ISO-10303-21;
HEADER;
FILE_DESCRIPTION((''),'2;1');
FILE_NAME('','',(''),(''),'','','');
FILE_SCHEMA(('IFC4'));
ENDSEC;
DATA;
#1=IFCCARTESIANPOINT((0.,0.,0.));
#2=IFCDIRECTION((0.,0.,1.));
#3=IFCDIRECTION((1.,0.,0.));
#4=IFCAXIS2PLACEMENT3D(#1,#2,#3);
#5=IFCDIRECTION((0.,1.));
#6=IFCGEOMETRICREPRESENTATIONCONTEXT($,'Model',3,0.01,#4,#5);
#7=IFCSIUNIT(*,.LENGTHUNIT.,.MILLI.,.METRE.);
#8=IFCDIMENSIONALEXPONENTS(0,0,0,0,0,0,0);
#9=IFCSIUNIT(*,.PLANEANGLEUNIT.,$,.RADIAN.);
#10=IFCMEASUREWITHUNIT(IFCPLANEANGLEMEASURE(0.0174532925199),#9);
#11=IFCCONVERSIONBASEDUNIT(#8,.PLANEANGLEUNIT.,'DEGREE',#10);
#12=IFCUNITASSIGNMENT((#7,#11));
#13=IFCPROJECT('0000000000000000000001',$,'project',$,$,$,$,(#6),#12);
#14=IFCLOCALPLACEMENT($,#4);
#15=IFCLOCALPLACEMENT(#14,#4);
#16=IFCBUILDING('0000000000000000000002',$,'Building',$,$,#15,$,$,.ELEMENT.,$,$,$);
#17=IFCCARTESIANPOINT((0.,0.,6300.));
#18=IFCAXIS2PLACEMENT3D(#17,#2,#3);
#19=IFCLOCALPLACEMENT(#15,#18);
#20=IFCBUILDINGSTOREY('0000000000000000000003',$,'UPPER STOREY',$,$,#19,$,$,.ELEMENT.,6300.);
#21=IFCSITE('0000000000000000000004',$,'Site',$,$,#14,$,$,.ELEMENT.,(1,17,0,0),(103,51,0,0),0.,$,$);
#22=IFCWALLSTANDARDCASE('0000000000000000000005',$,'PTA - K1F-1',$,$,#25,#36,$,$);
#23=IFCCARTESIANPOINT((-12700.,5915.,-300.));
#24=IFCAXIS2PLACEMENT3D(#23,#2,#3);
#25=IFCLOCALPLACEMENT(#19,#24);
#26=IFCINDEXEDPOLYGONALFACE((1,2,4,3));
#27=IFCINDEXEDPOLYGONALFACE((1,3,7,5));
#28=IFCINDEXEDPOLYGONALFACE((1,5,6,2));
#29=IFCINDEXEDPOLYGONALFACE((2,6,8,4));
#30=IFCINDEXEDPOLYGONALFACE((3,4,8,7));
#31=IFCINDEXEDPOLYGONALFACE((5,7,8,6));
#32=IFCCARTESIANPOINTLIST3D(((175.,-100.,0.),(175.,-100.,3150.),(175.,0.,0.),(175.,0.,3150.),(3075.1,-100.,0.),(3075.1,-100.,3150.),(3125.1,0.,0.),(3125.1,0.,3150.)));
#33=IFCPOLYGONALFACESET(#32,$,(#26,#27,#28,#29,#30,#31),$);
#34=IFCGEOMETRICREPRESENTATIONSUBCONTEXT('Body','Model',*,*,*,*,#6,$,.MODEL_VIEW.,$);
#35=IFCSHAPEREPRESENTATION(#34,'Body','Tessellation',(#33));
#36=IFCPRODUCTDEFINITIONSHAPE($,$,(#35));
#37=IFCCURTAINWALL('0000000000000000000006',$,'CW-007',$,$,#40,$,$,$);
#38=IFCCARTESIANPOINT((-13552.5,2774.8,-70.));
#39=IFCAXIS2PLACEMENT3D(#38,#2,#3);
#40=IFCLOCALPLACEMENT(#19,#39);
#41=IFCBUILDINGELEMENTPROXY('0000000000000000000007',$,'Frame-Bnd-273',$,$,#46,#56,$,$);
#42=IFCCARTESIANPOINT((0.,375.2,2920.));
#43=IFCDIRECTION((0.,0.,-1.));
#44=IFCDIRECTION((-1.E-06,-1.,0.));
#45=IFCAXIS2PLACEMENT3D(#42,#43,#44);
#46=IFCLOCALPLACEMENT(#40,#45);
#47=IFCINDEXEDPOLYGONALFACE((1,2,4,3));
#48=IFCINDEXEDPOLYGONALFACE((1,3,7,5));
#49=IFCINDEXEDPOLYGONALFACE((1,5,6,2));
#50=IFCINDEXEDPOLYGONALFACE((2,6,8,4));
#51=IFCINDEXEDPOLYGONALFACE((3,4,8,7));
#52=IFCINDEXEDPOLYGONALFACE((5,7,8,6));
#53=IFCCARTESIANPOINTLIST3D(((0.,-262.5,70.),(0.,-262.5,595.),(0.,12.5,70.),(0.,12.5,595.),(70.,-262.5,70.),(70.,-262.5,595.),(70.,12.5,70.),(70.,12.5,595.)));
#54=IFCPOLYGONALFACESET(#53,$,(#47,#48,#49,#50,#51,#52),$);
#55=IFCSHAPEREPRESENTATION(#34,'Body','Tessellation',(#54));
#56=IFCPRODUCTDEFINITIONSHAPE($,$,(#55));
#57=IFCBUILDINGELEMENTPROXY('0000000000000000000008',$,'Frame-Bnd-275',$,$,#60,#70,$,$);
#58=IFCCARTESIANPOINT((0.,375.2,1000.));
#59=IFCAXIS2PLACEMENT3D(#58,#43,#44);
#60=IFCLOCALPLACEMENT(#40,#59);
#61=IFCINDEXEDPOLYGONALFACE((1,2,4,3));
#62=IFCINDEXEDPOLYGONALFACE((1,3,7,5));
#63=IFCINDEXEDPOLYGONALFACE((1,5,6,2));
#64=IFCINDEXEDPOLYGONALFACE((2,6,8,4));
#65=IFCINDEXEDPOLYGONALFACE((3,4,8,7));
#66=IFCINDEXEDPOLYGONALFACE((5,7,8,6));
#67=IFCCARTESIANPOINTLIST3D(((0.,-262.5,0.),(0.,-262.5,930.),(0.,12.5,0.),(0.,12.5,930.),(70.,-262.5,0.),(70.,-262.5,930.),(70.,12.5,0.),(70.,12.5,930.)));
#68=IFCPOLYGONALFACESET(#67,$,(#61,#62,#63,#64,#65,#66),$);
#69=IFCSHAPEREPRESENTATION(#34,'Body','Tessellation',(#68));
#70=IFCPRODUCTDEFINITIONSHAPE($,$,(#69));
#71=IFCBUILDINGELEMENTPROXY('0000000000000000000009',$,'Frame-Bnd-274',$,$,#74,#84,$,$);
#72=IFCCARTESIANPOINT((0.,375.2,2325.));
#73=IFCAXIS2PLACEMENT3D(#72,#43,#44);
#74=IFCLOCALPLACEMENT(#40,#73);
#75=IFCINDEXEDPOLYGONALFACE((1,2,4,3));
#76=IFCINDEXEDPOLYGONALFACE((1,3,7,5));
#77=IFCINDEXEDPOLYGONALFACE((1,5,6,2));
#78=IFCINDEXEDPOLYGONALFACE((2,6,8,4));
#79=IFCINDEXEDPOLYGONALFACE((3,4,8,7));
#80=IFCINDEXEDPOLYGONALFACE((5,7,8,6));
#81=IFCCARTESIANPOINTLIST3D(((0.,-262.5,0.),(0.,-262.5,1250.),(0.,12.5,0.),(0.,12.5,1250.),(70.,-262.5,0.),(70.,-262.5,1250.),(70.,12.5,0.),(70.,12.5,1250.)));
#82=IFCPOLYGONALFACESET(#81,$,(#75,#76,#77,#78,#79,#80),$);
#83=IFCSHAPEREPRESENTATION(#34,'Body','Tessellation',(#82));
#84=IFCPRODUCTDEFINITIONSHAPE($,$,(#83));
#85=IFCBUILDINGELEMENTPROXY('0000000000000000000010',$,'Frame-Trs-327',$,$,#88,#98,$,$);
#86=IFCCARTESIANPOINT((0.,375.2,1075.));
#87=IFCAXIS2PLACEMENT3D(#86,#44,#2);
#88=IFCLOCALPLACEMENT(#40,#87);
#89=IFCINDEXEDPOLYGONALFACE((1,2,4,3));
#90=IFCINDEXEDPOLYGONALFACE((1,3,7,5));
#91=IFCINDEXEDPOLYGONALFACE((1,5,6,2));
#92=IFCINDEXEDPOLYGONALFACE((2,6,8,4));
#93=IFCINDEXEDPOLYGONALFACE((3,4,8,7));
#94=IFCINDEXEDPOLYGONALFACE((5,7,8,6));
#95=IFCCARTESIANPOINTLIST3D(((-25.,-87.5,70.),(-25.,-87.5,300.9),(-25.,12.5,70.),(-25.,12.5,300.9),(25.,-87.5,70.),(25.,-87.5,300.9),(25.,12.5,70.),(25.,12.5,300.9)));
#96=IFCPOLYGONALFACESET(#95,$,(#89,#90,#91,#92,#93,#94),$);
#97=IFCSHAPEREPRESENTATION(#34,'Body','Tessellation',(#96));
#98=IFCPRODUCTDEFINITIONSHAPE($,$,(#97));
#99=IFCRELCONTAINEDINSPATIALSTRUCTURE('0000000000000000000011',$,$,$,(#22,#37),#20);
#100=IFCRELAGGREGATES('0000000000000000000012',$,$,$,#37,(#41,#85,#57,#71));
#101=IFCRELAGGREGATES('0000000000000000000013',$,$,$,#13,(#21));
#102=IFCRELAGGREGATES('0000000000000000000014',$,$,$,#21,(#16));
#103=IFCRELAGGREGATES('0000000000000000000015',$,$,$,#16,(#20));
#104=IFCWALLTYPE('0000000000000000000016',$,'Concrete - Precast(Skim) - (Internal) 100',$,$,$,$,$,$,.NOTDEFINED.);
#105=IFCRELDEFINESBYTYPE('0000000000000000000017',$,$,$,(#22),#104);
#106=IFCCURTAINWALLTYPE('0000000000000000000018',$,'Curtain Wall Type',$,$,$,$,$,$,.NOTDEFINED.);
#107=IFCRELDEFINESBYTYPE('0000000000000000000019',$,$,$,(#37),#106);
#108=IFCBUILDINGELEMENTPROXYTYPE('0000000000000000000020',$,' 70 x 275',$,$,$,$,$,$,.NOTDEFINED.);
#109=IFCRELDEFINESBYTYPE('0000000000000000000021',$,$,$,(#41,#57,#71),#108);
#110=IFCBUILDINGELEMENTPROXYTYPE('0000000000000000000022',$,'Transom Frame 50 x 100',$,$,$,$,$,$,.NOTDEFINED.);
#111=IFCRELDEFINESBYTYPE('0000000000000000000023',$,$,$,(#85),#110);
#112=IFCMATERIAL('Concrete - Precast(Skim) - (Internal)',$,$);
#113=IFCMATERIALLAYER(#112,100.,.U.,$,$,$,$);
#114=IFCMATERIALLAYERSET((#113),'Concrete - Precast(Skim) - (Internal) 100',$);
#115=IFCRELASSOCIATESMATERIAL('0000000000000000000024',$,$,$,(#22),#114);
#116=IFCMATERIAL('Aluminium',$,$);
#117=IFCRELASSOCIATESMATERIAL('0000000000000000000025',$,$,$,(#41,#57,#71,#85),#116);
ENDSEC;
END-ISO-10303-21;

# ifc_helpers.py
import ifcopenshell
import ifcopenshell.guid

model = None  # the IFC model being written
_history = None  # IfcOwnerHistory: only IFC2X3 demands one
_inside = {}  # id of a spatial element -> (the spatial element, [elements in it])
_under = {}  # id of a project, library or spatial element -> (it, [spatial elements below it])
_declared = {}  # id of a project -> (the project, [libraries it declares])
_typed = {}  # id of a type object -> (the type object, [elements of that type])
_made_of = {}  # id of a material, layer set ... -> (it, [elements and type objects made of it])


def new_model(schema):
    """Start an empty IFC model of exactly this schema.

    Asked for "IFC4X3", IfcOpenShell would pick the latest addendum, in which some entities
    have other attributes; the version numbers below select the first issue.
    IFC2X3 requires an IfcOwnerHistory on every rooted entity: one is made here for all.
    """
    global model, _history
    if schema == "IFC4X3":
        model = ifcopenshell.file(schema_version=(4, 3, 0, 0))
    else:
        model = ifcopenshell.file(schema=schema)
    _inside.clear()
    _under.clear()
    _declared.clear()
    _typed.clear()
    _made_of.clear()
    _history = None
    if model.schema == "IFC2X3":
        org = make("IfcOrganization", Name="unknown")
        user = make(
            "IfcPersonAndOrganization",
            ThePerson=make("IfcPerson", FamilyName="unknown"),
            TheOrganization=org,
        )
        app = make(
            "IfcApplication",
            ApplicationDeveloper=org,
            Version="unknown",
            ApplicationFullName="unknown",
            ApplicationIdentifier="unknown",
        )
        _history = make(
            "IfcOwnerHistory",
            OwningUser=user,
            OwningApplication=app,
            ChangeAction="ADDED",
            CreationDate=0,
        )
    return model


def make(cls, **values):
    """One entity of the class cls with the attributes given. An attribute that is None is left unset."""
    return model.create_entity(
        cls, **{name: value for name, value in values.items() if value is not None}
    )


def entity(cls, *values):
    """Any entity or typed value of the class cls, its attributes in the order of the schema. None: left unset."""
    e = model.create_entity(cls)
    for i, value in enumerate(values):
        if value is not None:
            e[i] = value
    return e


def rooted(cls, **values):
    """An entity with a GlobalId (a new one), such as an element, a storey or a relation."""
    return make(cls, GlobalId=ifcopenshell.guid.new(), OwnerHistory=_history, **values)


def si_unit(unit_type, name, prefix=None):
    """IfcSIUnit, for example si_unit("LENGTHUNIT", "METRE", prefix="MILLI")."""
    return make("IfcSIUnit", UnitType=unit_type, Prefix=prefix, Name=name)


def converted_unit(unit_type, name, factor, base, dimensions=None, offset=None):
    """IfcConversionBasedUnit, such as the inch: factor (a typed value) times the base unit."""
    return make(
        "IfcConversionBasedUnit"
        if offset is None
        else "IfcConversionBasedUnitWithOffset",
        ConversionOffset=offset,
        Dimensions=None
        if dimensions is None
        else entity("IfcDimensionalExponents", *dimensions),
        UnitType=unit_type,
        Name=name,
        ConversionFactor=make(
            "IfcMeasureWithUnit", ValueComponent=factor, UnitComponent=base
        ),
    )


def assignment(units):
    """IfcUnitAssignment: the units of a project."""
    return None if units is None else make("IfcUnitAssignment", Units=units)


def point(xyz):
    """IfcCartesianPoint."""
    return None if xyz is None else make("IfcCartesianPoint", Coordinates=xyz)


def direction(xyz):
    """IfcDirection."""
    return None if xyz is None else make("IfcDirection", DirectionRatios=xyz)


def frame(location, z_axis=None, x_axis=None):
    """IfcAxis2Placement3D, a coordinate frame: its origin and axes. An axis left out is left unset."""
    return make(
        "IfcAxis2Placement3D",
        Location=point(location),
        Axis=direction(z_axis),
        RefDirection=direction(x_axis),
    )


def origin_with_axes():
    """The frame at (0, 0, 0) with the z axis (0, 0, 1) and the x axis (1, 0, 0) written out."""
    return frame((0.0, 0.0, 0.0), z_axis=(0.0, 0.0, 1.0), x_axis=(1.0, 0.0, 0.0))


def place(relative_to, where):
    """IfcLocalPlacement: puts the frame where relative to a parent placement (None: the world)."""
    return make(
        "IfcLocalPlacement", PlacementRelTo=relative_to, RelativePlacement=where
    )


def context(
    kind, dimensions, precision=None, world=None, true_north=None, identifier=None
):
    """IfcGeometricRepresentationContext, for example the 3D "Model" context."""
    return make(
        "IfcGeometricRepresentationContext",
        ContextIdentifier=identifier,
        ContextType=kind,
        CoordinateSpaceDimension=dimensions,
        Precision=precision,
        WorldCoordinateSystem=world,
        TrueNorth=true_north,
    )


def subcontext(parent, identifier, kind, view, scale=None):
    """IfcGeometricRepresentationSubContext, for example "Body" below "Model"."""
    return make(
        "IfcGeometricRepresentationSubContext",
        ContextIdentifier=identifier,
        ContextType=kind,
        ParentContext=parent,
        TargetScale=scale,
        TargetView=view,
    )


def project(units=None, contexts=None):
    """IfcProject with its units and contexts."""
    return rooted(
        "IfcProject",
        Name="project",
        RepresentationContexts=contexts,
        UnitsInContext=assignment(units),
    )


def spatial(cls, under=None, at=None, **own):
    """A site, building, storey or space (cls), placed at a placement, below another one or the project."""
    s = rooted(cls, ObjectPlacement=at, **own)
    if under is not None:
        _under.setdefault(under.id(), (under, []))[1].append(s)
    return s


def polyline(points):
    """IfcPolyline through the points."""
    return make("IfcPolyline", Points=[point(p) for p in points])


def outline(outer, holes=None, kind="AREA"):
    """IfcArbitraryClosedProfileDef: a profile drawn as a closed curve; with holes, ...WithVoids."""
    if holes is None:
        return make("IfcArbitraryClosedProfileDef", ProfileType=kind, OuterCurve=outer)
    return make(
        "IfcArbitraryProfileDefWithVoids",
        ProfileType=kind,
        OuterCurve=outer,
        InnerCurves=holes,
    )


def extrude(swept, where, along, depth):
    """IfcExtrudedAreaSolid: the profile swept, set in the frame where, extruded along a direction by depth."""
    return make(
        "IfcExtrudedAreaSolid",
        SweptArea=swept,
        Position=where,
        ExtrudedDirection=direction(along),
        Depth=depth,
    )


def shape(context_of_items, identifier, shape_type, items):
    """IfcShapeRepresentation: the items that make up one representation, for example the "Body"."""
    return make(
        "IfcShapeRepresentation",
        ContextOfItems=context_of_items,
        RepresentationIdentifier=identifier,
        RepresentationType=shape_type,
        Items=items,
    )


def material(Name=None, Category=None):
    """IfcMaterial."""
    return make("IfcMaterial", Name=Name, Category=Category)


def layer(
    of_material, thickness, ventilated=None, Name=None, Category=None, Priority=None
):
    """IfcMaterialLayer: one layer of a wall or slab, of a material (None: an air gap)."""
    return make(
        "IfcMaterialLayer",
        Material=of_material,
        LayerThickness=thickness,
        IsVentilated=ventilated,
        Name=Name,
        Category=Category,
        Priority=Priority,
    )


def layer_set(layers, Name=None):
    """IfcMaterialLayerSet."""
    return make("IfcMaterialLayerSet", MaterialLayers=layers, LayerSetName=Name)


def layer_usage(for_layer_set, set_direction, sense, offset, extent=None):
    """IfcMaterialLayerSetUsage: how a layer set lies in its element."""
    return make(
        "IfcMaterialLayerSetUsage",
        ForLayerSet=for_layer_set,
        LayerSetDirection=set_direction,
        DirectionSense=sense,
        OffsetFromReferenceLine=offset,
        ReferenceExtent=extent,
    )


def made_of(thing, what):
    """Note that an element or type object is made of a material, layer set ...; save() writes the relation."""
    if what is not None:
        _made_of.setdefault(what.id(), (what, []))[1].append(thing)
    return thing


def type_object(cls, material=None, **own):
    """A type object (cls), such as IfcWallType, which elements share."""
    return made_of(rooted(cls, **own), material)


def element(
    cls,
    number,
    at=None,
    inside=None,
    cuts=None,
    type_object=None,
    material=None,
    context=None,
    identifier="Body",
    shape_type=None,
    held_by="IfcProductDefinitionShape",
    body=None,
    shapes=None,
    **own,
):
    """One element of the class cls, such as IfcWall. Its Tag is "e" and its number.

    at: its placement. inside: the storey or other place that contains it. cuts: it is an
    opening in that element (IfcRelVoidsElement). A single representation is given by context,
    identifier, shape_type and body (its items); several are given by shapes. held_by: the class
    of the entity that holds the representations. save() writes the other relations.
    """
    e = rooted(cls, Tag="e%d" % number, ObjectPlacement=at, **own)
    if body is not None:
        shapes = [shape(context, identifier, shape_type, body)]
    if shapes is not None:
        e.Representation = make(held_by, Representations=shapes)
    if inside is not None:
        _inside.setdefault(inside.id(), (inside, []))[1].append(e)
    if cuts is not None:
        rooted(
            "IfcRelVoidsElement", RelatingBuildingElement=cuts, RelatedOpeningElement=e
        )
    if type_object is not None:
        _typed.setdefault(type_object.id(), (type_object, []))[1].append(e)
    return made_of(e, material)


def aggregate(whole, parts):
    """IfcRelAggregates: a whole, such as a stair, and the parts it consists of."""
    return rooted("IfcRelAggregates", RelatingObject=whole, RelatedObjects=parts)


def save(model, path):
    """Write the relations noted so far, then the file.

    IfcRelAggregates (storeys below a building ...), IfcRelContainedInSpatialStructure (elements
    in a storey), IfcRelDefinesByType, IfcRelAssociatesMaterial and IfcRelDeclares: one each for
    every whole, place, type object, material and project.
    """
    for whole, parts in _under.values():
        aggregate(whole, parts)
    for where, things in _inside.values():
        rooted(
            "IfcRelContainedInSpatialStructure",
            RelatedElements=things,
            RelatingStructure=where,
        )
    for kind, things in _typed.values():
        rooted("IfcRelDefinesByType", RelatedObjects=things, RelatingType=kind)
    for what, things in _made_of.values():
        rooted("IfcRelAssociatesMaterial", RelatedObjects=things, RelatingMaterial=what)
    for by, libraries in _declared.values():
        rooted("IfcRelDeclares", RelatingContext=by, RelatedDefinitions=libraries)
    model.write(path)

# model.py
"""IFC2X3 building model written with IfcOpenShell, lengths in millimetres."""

from ifc_helpers import new_model, entity, si_unit, converted_unit, direction, frame, origin_with_axes, place, context, subcontext, project, spatial, polyline, outline, extrude, material, layer, layer_set, layer_usage, type_object, element, aggregate, save


model = new_model("IFC2X3")

# Units and contexts
model_context = context("Model", 3, precision=0.01, world=origin_with_axes(), true_north=direction((0.0, 1.0)))
body_context = subcontext(model_context, "Body", "Model", "MODEL_VIEW")
ifc_project = project(units=[si_unit("LENGTHUNIT", "METRE", prefix="MILLI"), converted_unit("PLANEANGLEUNIT", "DEGREE", entity("IfcPlaneAngleMeasure", 0.0174532925199), si_unit("PLANEANGLEUNIT", "RADIAN"), dimensions=[0, 0, 0, 0, 0, 0, 0])], contexts=[model_context])

# Site, building, storey
site_placement = place(None, origin_with_axes())
site = spatial("IfcSite", under=ifc_project, at=site_placement, Name="Site", CompositionType="ELEMENT", RefLatitude=(1, 17, 0, 0), RefLongitude=(103, 51, 0, 0), RefElevation=0.0)
building_placement = place(site_placement, origin_with_axes())
building = spatial("IfcBuilding", under=site, at=building_placement, Name="Building", CompositionType="ELEMENT")
storey_placement = place(building_placement, frame((0.0, 0.0, 6300.0), z_axis=(0.0, 0.0, 1.0), x_axis=(1.0, 0.0, 0.0)))
storey = spatial("IfcBuildingStorey", under=building, at=storey_placement, Name="UPPER STOREY", CompositionType="ELEMENT", Elevation=6300.0)

# Shared definitions
ifc_material_1 = material(Name="Concrete - Precast(Skim) - (Internal)")

# Wall
ifc_layer_1 = layer(ifc_material_1, 100.0, ventilated="UNKNOWN")
ifc_layer_set_1 = layer_set([ifc_layer_1], Name="Concrete - Precast(Skim) - (Internal) 100")
ifc_layer_usage_1 = layer_usage(ifc_layer_set_1, "AXIS2", "NEGATIVE", 0.0)
wall_type_1 = type_object("IfcWallType", Name="Concrete - Precast(Skim) - (Internal) 100", PredefinedType="NOTDEFINED")
wall_1_placement = place(storey_placement, frame((-12700.0, 5915.0, -300.0), z_axis=(0.0, 0.0, 1.0), x_axis=(1.0, 0.0, 0.0)))
element("IfcWallStandardCase", 1, at=wall_1_placement, inside=storey, type_object=wall_type_1, material=ifc_layer_usage_1, Name="PTA - K1F-1", context=body_context, shape_type="SweptSolid", body=[
    extrude(outline(polyline([(175.0, -100.0), (3075.1, -100.0), (3125.1, 0.0), (175.0, 0.0), (175.0, -100.0)])), origin_with_axes(), (0.0, 0.0, 1.0), 3150.0),
])

# Curtain wall, building element proxies
curtain_wall_type = type_object("IfcCurtainWallType", Name="Curtain Wall Type", PredefinedType="NOTDEFINED")
curtain_wall_placement = place(storey_placement, frame((-13552.5, 2774.8, -70.0), z_axis=(0.0, 0.0, 1.0), x_axis=(1.0, 0.0, 0.0)))
curtain_wall = element("IfcCurtainWall", 2, at=curtain_wall_placement, inside=storey, type_object=curtain_wall_type, Name="CW-007")
ifc_material_2 = material(Name="Aluminium")
building_element_proxy_type_1 = type_object("IfcBuildingElementProxyType", Name=" 70 x 275", PredefinedType="NOTDEFINED")
proxy_1_placement = place(curtain_wall_placement, frame((0.0, 375.2, 2920.0), z_axis=(0.0, 0.0, -1.0), x_axis=(-0.000001, -1.0, 0.0)))
proxy_1 = element("IfcBuildingElementProxy", 3, at=proxy_1_placement, type_object=building_element_proxy_type_1, material=ifc_material_2, Name="Frame-Bnd-273", context=body_context, shape_type="SweptSolid", body=[
    extrude(outline(polyline([(262.5, 70.0), (-12.5, 70.0), (-12.5, 0.0), (262.5, 0.0), (262.5, 70.0)])), frame((0.0, 0.0, 70.0), z_axis=(0.0, 0.0, 1.0), x_axis=(-0.000001, -1.0, 0.0)), (0.0, 0.0, 1.0), 525.0),
])
proxy_2_placement = place(curtain_wall_placement, frame((0.0, 375.2, 1000.0), z_axis=(0.0, 0.0, -1.0), x_axis=(-0.000001, -1.0, 0.0)))
proxy_2 = element("IfcBuildingElementProxy", 4, at=proxy_2_placement, type_object=building_element_proxy_type_1, material=ifc_material_2, Name="Frame-Bnd-275", context=body_context, shape_type="SweptSolid", body=[
    extrude(outline(polyline([(262.5, 70.0), (-12.5, 70.0), (-12.5, 0.0), (262.5, 0.0), (262.5, 70.0)])), frame((0.0, 0.0, 0.0), z_axis=(0.0, 0.0, 1.0), x_axis=(-0.000001, -1.0, 0.0)), (0.0, 0.0, 1.0), 930.0),
])
proxy_3_placement = place(curtain_wall_placement, frame((0.0, 375.2, 2325.0), z_axis=(0.0, 0.0, -1.0), x_axis=(-0.000001, -1.0, 0.0)))
proxy_3 = element("IfcBuildingElementProxy", 5, at=proxy_3_placement, type_object=building_element_proxy_type_1, material=ifc_material_2, Name="Frame-Bnd-274", context=body_context, shape_type="SweptSolid", body=[
    extrude(outline(polyline([(262.5, 70.0), (-12.5, 70.0), (-12.5, 0.0), (262.5, 0.0), (262.5, 70.0)])), frame((0.0, 0.0, 0.0), z_axis=(0.0, 0.0, 1.0), x_axis=(-0.000001, -1.0, 0.0)), (0.0, 0.0, 1.0), 1250.0),
])
building_element_proxy_type_2 = type_object("IfcBuildingElementProxyType", Name="Transom Frame 50 x 100", PredefinedType="NOTDEFINED")
proxy_4_placement = place(curtain_wall_placement, frame((0.0, 375.2, 1075.0), z_axis=(-0.000001, -1.0, 0.0), x_axis=(0.0, 0.0, 1.0)))
proxy_4 = element("IfcBuildingElementProxy", 6, at=proxy_4_placement, type_object=building_element_proxy_type_2, material=ifc_material_2, Name="Frame-Trs-327", context=body_context, shape_type="SweptSolid", body=[
    extrude(outline(polyline([(-87.5, -25.0), (12.5, -25.0), (12.5, 25.0), (-87.5, 25.0), (-87.5, -25.0)])), frame((0.0, 0.0, 70.0), z_axis=(0.0, 0.0, 1.0), x_axis=(0.0, 1.0, 0.0)), (0.0, 0.0, 1.0), 230.9),
])
aggregate(curtain_wall, [proxy_1, proxy_4, proxy_2, proxy_3])

save(model, "model.ifc")
